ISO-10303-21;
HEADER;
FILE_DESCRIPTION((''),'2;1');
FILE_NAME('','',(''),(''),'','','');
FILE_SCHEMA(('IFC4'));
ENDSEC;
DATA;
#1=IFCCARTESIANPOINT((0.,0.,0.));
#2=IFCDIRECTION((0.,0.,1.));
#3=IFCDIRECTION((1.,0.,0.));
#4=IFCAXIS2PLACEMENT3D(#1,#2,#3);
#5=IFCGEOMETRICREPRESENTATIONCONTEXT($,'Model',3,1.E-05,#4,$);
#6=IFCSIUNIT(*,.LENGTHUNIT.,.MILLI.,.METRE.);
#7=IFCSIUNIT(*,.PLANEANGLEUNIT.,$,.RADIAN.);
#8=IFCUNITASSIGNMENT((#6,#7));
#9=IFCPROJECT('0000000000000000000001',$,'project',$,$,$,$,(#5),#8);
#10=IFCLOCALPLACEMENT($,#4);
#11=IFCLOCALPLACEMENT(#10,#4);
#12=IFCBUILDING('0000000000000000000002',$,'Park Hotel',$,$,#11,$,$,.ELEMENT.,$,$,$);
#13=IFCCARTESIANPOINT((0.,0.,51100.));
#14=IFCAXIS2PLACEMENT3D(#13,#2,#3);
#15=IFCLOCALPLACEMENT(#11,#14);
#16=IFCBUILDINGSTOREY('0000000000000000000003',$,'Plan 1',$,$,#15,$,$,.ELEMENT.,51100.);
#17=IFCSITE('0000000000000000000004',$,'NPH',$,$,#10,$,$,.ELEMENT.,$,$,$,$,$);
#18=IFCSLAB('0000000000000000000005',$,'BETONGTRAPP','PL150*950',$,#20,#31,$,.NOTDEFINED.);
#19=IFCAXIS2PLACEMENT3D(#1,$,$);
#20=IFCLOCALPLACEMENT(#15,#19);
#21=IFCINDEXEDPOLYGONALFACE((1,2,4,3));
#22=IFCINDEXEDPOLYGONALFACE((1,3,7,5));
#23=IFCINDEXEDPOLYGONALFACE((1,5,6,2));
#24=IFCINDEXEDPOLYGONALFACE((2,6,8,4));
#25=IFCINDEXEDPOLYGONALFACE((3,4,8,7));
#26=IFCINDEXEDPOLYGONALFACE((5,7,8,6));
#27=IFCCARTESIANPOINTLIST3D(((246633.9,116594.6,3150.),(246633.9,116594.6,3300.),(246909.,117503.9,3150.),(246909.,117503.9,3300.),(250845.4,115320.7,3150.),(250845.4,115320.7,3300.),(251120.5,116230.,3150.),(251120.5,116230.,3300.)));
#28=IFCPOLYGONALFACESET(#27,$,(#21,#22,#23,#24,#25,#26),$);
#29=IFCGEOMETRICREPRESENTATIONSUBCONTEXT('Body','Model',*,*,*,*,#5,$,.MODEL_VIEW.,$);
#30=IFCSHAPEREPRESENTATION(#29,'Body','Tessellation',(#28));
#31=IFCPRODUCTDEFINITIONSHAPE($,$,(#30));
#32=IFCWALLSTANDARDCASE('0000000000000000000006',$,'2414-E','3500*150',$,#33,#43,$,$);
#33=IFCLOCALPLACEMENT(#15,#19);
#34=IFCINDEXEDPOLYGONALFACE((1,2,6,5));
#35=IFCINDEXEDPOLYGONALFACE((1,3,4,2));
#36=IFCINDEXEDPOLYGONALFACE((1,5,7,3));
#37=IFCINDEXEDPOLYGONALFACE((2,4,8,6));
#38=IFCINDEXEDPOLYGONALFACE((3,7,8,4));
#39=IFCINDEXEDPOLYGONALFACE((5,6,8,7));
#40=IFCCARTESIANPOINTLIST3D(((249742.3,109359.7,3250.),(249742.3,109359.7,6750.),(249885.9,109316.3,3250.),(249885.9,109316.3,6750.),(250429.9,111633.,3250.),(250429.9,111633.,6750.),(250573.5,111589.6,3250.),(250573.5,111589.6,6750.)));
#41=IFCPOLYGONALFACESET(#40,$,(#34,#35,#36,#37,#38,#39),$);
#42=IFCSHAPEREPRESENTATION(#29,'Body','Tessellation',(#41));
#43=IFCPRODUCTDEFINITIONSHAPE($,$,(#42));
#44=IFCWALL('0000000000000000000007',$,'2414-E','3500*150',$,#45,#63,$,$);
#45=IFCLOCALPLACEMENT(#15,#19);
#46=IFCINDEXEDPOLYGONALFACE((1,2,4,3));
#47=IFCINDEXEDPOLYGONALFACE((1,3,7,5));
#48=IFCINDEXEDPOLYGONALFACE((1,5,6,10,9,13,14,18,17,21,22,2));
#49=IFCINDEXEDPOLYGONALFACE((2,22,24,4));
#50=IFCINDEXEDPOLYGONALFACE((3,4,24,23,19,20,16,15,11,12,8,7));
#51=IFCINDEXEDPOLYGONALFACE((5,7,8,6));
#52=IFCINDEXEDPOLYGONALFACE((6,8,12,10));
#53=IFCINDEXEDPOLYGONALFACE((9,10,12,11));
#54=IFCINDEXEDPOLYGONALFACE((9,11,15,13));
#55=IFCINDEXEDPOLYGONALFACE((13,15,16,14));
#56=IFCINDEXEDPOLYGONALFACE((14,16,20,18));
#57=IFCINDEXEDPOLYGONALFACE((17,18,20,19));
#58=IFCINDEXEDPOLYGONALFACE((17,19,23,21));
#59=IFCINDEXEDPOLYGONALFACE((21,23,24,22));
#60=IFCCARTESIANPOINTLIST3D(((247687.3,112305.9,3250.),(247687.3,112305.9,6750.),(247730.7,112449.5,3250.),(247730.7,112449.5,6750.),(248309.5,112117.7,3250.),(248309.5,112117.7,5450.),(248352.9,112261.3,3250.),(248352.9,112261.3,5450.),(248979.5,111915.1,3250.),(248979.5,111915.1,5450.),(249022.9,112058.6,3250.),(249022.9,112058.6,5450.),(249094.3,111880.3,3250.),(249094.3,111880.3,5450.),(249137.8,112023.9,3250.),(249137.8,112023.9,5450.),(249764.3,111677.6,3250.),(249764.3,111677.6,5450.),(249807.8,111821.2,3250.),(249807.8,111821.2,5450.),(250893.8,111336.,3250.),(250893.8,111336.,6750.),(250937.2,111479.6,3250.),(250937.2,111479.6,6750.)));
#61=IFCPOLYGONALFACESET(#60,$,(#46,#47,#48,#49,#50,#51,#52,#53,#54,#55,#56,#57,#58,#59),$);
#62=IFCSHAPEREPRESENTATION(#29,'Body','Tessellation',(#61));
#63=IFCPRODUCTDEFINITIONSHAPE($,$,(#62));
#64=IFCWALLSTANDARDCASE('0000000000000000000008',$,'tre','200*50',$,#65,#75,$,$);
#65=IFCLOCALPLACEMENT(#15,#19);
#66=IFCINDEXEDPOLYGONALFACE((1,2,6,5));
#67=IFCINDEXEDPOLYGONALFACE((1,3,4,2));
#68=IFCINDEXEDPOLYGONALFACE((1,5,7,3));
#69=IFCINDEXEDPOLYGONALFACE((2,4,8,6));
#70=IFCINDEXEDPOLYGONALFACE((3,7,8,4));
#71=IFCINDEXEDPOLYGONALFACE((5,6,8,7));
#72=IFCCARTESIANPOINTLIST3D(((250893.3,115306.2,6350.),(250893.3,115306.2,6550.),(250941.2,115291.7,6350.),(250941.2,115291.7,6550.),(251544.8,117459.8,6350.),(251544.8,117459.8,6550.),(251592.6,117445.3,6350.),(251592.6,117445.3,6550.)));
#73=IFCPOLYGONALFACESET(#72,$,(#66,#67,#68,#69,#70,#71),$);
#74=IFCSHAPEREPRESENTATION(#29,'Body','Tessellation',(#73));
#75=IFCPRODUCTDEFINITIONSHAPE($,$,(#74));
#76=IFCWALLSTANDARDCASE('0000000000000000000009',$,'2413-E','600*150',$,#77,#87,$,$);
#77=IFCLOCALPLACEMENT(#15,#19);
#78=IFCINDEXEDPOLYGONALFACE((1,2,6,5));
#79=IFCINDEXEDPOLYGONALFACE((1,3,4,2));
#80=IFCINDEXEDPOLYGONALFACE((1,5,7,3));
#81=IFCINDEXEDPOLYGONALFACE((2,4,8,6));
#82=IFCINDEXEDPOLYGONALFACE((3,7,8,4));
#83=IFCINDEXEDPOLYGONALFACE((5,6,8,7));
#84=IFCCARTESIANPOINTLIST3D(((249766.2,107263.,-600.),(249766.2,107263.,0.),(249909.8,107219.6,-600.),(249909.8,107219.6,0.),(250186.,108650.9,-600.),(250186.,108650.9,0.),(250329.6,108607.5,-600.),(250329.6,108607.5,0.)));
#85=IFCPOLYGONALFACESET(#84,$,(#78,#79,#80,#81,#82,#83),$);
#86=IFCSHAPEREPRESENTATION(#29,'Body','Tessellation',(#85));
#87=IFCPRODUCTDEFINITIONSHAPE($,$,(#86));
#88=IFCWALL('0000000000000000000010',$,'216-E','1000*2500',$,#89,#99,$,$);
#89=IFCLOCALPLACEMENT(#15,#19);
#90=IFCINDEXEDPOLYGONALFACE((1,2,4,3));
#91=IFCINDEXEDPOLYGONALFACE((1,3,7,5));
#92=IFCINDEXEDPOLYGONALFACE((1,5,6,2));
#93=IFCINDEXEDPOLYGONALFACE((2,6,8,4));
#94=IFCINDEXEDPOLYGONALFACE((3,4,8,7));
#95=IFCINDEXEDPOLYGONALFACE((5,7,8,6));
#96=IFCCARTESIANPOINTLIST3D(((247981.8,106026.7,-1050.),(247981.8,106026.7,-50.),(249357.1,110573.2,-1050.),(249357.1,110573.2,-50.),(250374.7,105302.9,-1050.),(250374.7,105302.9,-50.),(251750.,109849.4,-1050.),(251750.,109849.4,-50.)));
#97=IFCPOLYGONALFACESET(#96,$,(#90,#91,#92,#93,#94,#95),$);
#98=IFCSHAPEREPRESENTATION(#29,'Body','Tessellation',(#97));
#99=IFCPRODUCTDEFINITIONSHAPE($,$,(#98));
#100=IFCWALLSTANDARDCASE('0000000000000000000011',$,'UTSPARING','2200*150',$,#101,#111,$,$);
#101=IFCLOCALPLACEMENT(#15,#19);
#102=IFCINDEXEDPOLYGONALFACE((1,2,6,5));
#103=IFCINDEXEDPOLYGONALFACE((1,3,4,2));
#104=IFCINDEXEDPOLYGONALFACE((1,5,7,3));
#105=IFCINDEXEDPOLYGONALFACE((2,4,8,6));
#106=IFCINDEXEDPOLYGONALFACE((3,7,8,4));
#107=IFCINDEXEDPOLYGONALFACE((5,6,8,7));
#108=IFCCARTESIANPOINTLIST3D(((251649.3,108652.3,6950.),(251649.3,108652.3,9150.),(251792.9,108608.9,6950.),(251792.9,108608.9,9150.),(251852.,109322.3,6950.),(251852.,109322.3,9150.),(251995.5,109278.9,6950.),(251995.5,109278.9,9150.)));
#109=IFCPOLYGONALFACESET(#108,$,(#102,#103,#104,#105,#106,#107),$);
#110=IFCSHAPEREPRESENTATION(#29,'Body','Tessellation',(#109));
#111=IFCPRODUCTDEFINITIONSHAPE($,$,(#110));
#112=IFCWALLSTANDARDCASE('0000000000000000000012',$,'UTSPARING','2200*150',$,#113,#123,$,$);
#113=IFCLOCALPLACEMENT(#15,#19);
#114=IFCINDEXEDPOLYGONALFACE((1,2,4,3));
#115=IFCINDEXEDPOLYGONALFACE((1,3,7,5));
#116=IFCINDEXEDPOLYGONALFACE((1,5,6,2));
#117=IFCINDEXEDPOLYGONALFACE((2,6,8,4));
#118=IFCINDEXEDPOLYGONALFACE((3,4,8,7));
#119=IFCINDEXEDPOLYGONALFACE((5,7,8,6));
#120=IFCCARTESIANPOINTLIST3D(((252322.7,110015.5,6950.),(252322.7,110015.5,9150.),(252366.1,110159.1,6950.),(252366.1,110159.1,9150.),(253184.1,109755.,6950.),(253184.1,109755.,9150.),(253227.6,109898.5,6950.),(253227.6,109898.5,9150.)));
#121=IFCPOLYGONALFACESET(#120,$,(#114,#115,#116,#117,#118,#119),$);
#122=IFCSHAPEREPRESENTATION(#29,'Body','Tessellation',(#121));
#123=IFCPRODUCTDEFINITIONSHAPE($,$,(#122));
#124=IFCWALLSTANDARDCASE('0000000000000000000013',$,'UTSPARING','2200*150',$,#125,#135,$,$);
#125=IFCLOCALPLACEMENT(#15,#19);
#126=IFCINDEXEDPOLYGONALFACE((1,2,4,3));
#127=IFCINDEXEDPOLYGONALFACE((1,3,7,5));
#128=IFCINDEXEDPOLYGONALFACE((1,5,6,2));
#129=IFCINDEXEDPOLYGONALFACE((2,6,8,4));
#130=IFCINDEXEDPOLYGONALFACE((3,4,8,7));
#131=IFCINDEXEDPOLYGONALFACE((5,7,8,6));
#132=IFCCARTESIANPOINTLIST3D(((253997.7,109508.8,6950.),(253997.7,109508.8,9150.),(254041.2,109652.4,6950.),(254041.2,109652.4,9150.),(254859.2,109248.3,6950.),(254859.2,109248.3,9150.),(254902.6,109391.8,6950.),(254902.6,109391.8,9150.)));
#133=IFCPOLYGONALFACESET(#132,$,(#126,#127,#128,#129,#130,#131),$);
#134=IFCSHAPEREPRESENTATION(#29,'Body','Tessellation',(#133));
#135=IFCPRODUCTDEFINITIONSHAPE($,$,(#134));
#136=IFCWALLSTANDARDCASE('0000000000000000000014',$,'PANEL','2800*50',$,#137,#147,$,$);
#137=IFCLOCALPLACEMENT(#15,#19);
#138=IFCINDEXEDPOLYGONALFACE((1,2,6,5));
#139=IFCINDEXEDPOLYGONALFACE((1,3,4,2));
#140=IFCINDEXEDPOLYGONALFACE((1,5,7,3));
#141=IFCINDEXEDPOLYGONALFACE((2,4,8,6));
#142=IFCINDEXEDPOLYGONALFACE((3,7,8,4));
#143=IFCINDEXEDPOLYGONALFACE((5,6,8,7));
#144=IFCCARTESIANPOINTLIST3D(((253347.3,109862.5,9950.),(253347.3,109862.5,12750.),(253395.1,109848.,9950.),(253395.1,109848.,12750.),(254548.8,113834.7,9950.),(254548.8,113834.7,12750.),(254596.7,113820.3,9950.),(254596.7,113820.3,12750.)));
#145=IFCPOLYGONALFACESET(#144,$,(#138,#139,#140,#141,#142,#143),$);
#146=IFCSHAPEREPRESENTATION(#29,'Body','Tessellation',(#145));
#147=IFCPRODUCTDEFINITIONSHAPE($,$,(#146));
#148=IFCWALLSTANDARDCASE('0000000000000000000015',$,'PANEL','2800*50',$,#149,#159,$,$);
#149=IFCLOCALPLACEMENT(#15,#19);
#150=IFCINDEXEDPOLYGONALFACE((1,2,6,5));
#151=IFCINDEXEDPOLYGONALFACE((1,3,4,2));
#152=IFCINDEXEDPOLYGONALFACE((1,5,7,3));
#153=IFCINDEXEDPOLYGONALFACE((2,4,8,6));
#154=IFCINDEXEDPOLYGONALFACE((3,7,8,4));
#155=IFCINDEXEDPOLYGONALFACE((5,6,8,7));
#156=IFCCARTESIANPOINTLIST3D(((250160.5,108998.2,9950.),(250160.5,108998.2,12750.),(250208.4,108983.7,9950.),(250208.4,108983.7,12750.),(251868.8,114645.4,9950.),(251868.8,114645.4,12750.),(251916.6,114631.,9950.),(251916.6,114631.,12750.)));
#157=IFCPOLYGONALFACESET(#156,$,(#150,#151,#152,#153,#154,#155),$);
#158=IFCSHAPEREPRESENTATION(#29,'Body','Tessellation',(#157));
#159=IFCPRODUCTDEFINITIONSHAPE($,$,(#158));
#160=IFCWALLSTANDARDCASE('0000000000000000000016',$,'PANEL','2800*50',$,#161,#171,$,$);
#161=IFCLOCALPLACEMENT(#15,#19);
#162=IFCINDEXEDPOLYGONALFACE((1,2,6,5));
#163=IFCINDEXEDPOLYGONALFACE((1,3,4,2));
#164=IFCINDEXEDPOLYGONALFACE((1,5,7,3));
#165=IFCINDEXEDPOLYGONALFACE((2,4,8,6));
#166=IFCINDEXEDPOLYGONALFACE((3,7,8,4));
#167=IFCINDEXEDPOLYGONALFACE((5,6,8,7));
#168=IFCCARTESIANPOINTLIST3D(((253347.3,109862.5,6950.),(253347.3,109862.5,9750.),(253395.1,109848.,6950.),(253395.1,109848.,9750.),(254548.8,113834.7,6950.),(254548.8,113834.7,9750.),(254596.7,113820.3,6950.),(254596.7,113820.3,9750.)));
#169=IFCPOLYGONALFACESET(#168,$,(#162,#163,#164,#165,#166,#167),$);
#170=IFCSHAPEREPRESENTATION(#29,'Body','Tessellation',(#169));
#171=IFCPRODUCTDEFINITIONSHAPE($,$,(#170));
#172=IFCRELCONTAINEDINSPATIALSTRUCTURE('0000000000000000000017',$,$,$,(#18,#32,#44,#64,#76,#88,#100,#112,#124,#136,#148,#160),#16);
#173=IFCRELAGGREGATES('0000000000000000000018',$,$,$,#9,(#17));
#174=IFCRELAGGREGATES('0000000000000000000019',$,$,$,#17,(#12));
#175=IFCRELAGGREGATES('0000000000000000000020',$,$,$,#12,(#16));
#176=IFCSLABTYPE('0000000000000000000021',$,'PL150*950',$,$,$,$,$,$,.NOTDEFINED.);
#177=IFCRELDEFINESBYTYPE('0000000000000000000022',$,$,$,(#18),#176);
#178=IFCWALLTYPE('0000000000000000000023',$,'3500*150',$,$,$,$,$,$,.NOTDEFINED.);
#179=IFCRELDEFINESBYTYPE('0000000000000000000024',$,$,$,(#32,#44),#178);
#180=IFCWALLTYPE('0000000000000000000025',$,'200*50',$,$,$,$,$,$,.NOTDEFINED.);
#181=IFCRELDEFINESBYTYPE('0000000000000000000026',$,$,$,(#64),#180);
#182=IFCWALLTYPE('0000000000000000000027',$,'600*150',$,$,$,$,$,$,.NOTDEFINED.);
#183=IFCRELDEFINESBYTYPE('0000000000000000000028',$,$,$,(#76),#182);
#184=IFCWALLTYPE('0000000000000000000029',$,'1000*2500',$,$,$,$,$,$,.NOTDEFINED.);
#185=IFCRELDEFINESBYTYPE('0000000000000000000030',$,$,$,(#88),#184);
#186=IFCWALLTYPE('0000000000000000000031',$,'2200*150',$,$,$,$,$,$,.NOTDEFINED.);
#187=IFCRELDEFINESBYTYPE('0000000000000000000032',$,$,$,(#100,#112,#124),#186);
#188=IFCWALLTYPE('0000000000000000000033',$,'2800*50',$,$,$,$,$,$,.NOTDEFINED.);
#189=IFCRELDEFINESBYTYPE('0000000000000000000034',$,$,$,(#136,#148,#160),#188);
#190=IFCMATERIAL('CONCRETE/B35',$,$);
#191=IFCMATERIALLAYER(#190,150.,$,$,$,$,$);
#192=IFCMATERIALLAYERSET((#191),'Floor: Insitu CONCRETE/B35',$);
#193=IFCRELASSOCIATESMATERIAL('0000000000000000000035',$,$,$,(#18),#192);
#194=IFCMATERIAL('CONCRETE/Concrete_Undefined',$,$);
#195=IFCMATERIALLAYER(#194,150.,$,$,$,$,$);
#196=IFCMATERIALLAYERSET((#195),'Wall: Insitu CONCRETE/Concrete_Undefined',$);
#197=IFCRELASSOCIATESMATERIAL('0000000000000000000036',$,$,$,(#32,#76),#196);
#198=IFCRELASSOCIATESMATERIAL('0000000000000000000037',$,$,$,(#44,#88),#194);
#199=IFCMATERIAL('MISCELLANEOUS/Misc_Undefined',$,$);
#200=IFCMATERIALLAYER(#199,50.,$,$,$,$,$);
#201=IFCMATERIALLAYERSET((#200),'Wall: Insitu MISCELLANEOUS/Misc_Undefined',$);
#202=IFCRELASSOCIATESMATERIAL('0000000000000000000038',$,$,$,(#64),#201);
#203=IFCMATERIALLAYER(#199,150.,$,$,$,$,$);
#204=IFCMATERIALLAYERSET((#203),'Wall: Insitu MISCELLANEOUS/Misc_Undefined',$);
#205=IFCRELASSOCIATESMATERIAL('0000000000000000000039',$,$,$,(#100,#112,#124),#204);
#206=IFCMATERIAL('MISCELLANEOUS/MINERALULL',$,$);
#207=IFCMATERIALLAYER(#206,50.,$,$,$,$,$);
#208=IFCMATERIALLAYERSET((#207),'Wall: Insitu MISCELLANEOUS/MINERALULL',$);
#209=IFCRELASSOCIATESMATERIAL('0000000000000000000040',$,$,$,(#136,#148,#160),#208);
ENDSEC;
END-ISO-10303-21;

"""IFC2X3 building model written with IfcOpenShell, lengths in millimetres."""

from ifc_helpers import new_model, si_unit, frame, frame_2d, origin_with_axes, place, context, subcontext, project, spatial, polyline, rectangle, outline, extrude, boolean, material, layer, layer_set, layer_usage, type_object, element, save


model = new_model("IFC2X3")

# Units and contexts
model_context = context("Model", 3, precision=1e-05, world=origin_with_axes())
body_context = subcontext(model_context, "Body", "Model", "MODEL_VIEW")
ifc_project = project(units=[si_unit("LENGTHUNIT", "METRE", prefix="MILLI"), si_unit("PLANEANGLEUNIT", "RADIAN")], contexts=[model_context])

# Site, building, storey
site_placement = place(None, origin_with_axes())
site = spatial("IfcSite", under=ifc_project, at=site_placement, Name="NPH", CompositionType="ELEMENT")
building_placement = place(site_placement, origin_with_axes())
building = spatial("IfcBuilding", under=site, at=building_placement, Name="Park Hotel", CompositionType="ELEMENT")
storey_placement = place(building_placement, frame((0.0, 0.0, 51100.0), z_axis=(0.0, 0.0, 1.0), x_axis=(1.0, 0.0, 0.0)))
storey = spatial("IfcBuildingStorey", under=building, at=storey_placement, Name="Plan 1", CompositionType="ELEMENT", Elevation=51100.0)

# Shared definitions
ifc_material_1 = material(Name="CONCRETE/Concrete_Undefined")

# Slab
ifc_material_2 = material(Name="CONCRETE/B35")
ifc_layer_1 = layer(ifc_material_2, 150.0)
ifc_layer_set_1 = layer_set([ifc_layer_1], Name="Floor: Insitu CONCRETE/B35")
ifc_layer_usage_1 = layer_usage(ifc_layer_set_1, "AXIS3", "POSITIVE", -75.0)
slab_type = type_object("IfcSlabType", Name="PL150*950", PredefinedType="NOTDEFINED")
slab_placement = place(storey_placement, frame((251120.5, 116230.0, 3225.0), z_axis=(0.0, 0.0, -1.0), x_axis=(-0.289538, -0.957167, 0.0)))
element("IfcSlab", 1, at=slab_placement, inside=storey, type_object=slab_type, material=ifc_layer_usage_1, Name="BETONGTRAPP", Description="PL150*950", PredefinedType="NOTDEFINED", context=body_context, shape_type="SweptSolid", body=[
    extrude(outline(polyline([(0.0, 0.0), (950.0, 0.0), (950.0, 4400.0), (0.0, 4400.0), (0.0, 0.0)])), frame((0.0, 0.0, -75.0), z_axis=(0.0, 0.0, 1.0), x_axis=(1.0, 0.0, 0.0)), (0.0, 0.0, 1.0), 150.0),
])

# Walls
ifc_layer_2 = layer(ifc_material_1, 150.0)
ifc_layer_set_2 = layer_set([ifc_layer_2], Name="Wall: Insitu CONCRETE/Concrete_Undefined")
ifc_layer_usage_2 = layer_usage(ifc_layer_set_2, "AXIS2", "POSITIVE", -75.0)
wall_type_1 = type_object("IfcWallType", Name="3500*150", PredefinedType="NOTDEFINED")
wall_1_placement = place(storey_placement, frame((250501.7, 111611.3, 3250.0), z_axis=(0.0, 0.0, 1.0), x_axis=(-0.289542, -0.957165, 0.0)))
element("IfcWallStandardCase", 2, at=wall_1_placement, inside=storey, type_object=wall_type_1, material=ifc_layer_usage_2, Name="2414-E", Description="3500*150", context=body_context, shape_type="SweptSolid", body=[
    extrude(rectangle(XDim=2375.0, YDim=150.0, at=frame_2d((0.0, 1187.5), x_axis=(0.0, -1.0))), frame((0.0, 0.0, 0.0), z_axis=(0.0, 0.0, 1.0), x_axis=(0.0, -1.0, 0.0)), (0.0, 0.0, 1.0), 3500.0),
])
wall_2_placement = place(storey_placement, frame((250915.5, 111407.8, 3250.0), z_axis=(0.0, 0.0, 1.0), x_axis=(-0.957166, 0.289539, 0.0)))
element("IfcWall", 3, at=wall_2_placement, inside=storey, type_object=wall_type_1, material=ifc_material_1, Name="2414-E", Description="3500*150", context=body_context, shape_type="CSG", body=[
    boolean("DIFFERENCE", boolean("DIFFERENCE", extrude(rectangle(XDim=3350.0, YDim=150.0, at=frame_2d((0.0, 1675.0), x_axis=(0.0, -1.0))), frame((0.0, 0.0, 0.0), z_axis=(0.0, 0.0, 1.0), x_axis=(0.0, -1.0, 0.0)), (0.0, 0.0, 1.0), 3500.0), extrude(rectangle(XDim=700.0, YDim=150.0, at=frame_2d((0.0, 350.0), x_axis=(0.0, -1.0))), frame((1180.0, 0.0, 0.0), z_axis=(0.0, 0.0, 1.0), x_axis=(-0.000003, -1.0, 0.0)), (0.0, 0.0, 1.0), 2200.0)), extrude(rectangle(XDim=700.0, YDim=150.0, at=frame_2d((0.0, 350.0), x_axis=(0.0, -1.0))), frame((2000.0, 0.0, 0.0), z_axis=(0.0, 0.0, 1.0), x_axis=(-0.000003, -1.0, 0.0)), (0.0, 0.0, 1.0), 2200.0)),
])
ifc_material_3 = material(Name="MISCELLANEOUS/Misc_Undefined")
ifc_layer_3 = layer(ifc_material_3, 50.0)
ifc_layer_set_3 = layer_set([ifc_layer_3], Name="Wall: Insitu MISCELLANEOUS/Misc_Undefined")
ifc_layer_usage_3 = layer_usage(ifc_layer_set_3, "AXIS2", "POSITIVE", -25.0)
wall_type_2 = type_object("IfcWallType", Name="200*50", PredefinedType="NOTDEFINED")
wall_3_placement = place(storey_placement, frame((251568.7, 117452.6, 6350.0), z_axis=(0.0, 0.0, 1.0), x_axis=(-0.289538, -0.957167, 0.0)))
element("IfcWallStandardCase", 4, at=wall_3_placement, inside=storey, type_object=wall_type_2, material=ifc_layer_usage_3, Name="tre", Description="200*50", context=body_context, shape_type="SweptSolid", body=[
    extrude(rectangle(XDim=2250.0, YDim=50.0, at=frame_2d((0.0, 1125.0), x_axis=(0.0, -1.0))), frame((0.0, 0.0, 0.0), z_axis=(0.0, 0.0, 1.0), x_axis=(0.0, -1.0, 0.0)), (0.0, 0.0, 1.0), 200.0),
])
ifc_layer_usage_4 = layer_usage(ifc_layer_set_2, "AXIS2", "POSITIVE", -75.0)
wall_type_3 = type_object("IfcWallType", Name="600*150", PredefinedType="NOTDEFINED")
wall_4_placement = place(storey_placement, frame((250257.8, 108629.2, -600.0), z_axis=(0.0, 0.0, 1.0), x_axis=(-0.289535, -0.957167, 0.0)))
element("IfcWallStandardCase", 5, at=wall_4_placement, inside=storey, type_object=wall_type_3, material=ifc_layer_usage_4, Name="2413-E", Description="600*150", context=body_context, shape_type="SweptSolid", body=[
    extrude(rectangle(XDim=1450.0, YDim=150.0, at=frame_2d((0.0, 725.0), x_axis=(0.0, -1.0))), frame((0.0, 0.0, 0.0), z_axis=(0.0, 0.0, 1.0), x_axis=(0.0, -1.0, 0.0)), (0.0, 0.0, 1.0), 600.0),
])
wall_type_4 = type_object("IfcWallType", Name="1000*2500", PredefinedType="NOTDEFINED")
wall_5_placement = place(storey_placement, frame((251750.0, 109849.4, -550.0), z_axis=(0.0, 0.0, 1.0), x_axis=(-0.957167, 0.289538, 0.0)))
element("IfcWall", 6, at=wall_5_placement, inside=storey, type_object=wall_type_4, material=ifc_material_1, Name="216-E", Description="1000*2500", context=body_context, shape_type="SweptSolid", body=[
    extrude(outline(polyline([(0.0, 0.0), (2500.0, 0.0), (2500.0, 4750.0), (0.0, 4750.0), (0.0, 0.0)])), frame((0.0, 0.0, -500.0), z_axis=(0.0, 0.0, 1.0), x_axis=(1.0, 0.0, 0.0)), (0.0, 0.0, 1.0), 1000.0),
])
ifc_layer_4 = layer(ifc_material_3, 150.0)
ifc_layer_set_4 = layer_set([ifc_layer_4], Name="Wall: Insitu MISCELLANEOUS/Misc_Undefined")
ifc_layer_usage_5 = layer_usage(ifc_layer_set_4, "AXIS2", "POSITIVE", -75.0)
wall_type_5 = type_object("IfcWallType", Name="2200*150", PredefinedType="NOTDEFINED")
wall_6_placement = place(storey_placement, frame((251923.8, 109300.6, 6950.0), z_axis=(0.0, 0.0, 1.0), x_axis=(-0.289534, -0.957168, 0.0)))
element("IfcWallStandardCase", 7, at=wall_6_placement, inside=storey, type_object=wall_type_5, material=ifc_layer_usage_5, Name="UTSPARING", Description="2200*150", context=body_context, shape_type="SweptSolid", body=[
    extrude(rectangle(XDim=700.0, YDim=150.0, at=frame_2d((0.0, 350.0), x_axis=(0.0, -1.0))), frame((0.0, 0.0, 0.0), z_axis=(0.0, 0.0, 1.0), x_axis=(0.0, -1.0, 0.0)), (0.0, 0.0, 1.0), 2200.0),
])
ifc_layer_usage_6 = layer_usage(ifc_layer_set_4, "AXIS2", "POSITIVE", -75.0)
wall_7_placement = place(storey_placement, frame((252344.4, 110087.3, 6950.0), z_axis=(0.0, 0.0, 1.0), x_axis=(0.957166, -0.289541, 0.0)))
element("IfcWallStandardCase", 8, at=wall_7_placement, inside=storey, type_object=wall_type_5, material=ifc_layer_usage_6, Name="UTSPARING", Description="2200*150", context=body_context, shape_type="SweptSolid", body=[
    extrude(rectangle(XDim=900.0, YDim=150.0, at=frame_2d((0.0, 450.0), x_axis=(0.0, -1.0))), frame((0.0, 0.0, 0.0), z_axis=(0.0, 0.0, 1.0), x_axis=(0.0, -1.0, 0.0)), (0.0, 0.0, 1.0), 2200.0),
])
ifc_layer_usage_7 = layer_usage(ifc_layer_set_4, "AXIS2", "POSITIVE", -75.0)
wall_8_placement = place(storey_placement, frame((254019.4, 109580.6, 6950.0), z_axis=(0.0, 0.0, 1.0), x_axis=(0.957166, -0.289541, 0.0)))
element("IfcWallStandardCase", 9, at=wall_8_placement, inside=storey, type_object=wall_type_5, material=ifc_layer_usage_7, Name="UTSPARING", Description="2200*150", context=body_context, shape_type="SweptSolid", body=[
    extrude(rectangle(XDim=900.0, YDim=150.0, at=frame_2d((0.0, 450.0), x_axis=(0.0, -1.0))), frame((0.0, 0.0, 0.0), z_axis=(0.0, 0.0, 1.0), x_axis=(0.0, -1.0, 0.0)), (0.0, 0.0, 1.0), 2200.0),
])
ifc_material_4 = material(Name="MISCELLANEOUS/MINERALULL")
ifc_layer_5 = layer(ifc_material_4, 50.0)
ifc_layer_set_5 = layer_set([ifc_layer_5], Name="Wall: Insitu MISCELLANEOUS/MINERALULL")
ifc_layer_usage_8 = layer_usage(ifc_layer_set_5, "AXIS2", "POSITIVE", -25.0)
wall_type_6 = type_object("IfcWallType", Name="2800*50", PredefinedType="NOTDEFINED")
wall_9_placement = place(storey_placement, frame((253371.2, 109855.3, 9950.0), z_axis=(0.0, 0.0, 1.0), x_axis=(0.289539, 0.957166, 0.0)))
element("IfcWallStandardCase", 10, at=wall_9_placement, inside=storey, type_object=wall_type_6, material=ifc_layer_usage_8, Name="PANEL", Description="2800*50", context=body_context, shape_type="SweptSolid", body=[
    extrude(rectangle(XDim=4150.0, YDim=50.0, at=frame_2d((0.0, 2075.0), x_axis=(0.0, -1.0))), frame((0.0, 0.0, 0.0), z_axis=(0.0, 0.0, 1.0), x_axis=(0.0, -1.0, 0.0)), (0.0, 0.0, 1.0), 2800.0),
])
ifc_layer_usage_9 = layer_usage(ifc_layer_set_5, "AXIS2", "POSITIVE", -25.0)
wall_10_placement = place(storey_placement, frame((250184.4, 108990.9, 9950.0), z_axis=(0.0, 0.0, 1.0), x_axis=(0.289539, 0.957166, 0.0)))
element("IfcWallStandardCase", 11, at=wall_10_placement, inside=storey, type_object=wall_type_6, material=ifc_layer_usage_9, Name="PANEL", Description="2800*50", context=body_context, shape_type="SweptSolid", body=[
    extrude(rectangle(XDim=5900.0, YDim=50.0, at=frame_2d((0.0, 2950.0), x_axis=(0.0, -1.0))), frame((0.0, 0.0, 0.0), z_axis=(0.0, 0.0, 1.0), x_axis=(0.0, -1.0, 0.0)), (0.0, 0.0, 1.0), 2800.0),
])
ifc_layer_usage_10 = layer_usage(ifc_layer_set_5, "AXIS2", "POSITIVE", -25.0)
wall_11_placement = place(storey_placement, frame((253371.2, 109855.3, 6950.0), z_axis=(0.0, 0.0, 1.0), x_axis=(0.289539, 0.957166, 0.0)))
element("IfcWallStandardCase", 12, at=wall_11_placement, inside=storey, type_object=wall_type_6, material=ifc_layer_usage_10, Name="PANEL", Description="2800*50", context=body_context, shape_type="SweptSolid", body=[
    extrude(rectangle(XDim=4150.0, YDim=50.0, at=frame_2d((0.0, 2075.0), x_axis=(0.0, -1.0))), frame((0.0, 0.0, 0.0), z_axis=(0.0, 0.0, 1.0), x_axis=(0.0, -1.0, 0.0)), (0.0, 0.0, 1.0), 2800.0),
])

save(model, "model.ifc")
